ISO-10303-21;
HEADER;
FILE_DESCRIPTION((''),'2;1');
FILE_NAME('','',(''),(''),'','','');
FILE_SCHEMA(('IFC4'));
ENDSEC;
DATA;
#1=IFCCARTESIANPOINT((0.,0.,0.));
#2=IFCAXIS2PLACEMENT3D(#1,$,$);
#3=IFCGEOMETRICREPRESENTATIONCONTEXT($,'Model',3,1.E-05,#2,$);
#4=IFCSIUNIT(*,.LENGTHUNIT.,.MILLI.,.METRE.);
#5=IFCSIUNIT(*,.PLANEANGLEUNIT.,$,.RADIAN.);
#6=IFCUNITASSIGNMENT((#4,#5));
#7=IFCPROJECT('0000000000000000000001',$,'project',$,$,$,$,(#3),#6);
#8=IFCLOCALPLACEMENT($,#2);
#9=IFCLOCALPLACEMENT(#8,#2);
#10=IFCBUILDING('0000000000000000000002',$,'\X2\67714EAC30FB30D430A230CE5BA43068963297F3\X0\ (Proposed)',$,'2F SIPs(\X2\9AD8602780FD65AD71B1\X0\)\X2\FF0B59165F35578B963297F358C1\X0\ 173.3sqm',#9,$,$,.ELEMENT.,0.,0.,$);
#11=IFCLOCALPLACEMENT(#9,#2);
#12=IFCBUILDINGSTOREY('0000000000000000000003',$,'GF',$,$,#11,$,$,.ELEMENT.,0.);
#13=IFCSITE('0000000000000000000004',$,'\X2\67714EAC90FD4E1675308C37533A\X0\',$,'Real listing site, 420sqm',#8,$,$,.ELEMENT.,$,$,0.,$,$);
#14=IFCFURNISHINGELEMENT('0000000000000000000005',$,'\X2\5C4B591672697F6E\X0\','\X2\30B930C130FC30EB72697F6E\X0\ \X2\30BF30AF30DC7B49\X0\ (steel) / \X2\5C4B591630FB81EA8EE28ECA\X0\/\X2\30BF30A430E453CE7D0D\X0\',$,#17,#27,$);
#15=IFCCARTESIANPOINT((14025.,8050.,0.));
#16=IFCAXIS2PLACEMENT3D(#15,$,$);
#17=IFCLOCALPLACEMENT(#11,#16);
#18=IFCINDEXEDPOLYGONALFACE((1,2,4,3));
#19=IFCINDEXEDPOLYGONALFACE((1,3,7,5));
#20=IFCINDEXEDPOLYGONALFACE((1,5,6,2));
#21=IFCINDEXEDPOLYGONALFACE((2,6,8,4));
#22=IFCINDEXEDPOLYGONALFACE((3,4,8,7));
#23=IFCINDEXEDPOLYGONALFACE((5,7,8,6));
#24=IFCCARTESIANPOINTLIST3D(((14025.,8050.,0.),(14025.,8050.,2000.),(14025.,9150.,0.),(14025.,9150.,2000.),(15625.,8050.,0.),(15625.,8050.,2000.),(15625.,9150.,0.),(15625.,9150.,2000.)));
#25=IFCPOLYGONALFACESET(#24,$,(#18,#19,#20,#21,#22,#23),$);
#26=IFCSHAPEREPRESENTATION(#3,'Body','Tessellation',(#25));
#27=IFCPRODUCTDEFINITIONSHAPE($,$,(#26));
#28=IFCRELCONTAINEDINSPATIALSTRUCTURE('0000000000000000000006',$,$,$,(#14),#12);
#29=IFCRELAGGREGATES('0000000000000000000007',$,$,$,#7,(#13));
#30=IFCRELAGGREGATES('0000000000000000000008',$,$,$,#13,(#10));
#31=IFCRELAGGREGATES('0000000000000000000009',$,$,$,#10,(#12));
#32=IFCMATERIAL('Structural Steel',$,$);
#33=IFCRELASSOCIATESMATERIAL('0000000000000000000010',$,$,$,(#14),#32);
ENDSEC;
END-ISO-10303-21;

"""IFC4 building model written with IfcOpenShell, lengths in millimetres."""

from ifc_helpers import new_model, si_unit, frame, frame_2d, origin, place, context, project, spatial, rectangle, extrude, material, element, save


model = new_model("IFC4")

# Units and contexts
model_context = context("Model", 3, precision=1e-05, world=origin())
ifc_project = project(units=[si_unit("LENGTHUNIT", "METRE", prefix="MILLI"), si_unit("PLANEANGLEUNIT", "RADIAN")], contexts=[model_context])

# Site, building, storey
site_placement = place(None, origin())
site = spatial("IfcSite", under=ifc_project, at=site_placement, Name="東京都世田谷区", ObjectType="Real listing site, 420sqm", CompositionType="ELEMENT", RefElevation=0.0)
building_placement = place(site_placement, origin())
building = spatial("IfcBuilding", under=site, at=building_placement, Name="東京・ピアノ室と防音 (Proposed)", ObjectType="2F SIPs(高性能断熱)＋外張型防音壁 173.3sqm", CompositionType="ELEMENT", ElevationOfRefHeight=0.0, ElevationOfTerrain=0.0)
storey_placement = place(building_placement, origin())
storey = spatial("IfcBuildingStorey", under=building, at=storey_placement, Name="GF", CompositionType="ELEMENT", Elevation=0.0)

# Shared definitions
ifc_material_1 = material(Name="Structural Steel")

# Furnishing element
furnishing_1_placement = place(storey_placement, frame((14025.0, 8050.0, 0.0)))
element("IfcFurnishingElement", 1, at=furnishing_1_placement, inside=storey, material=ifc_material_1, Name="屋外物置", Description="スチール物置 タクボ等 (steel) / 屋外・自転車/タイヤ収納", context=model_context, shape_type="SweptSolid", body=[
    extrude(rectangle(XDim=1600.0, YDim=1100.0, at=frame_2d((800.0, 550.0))), frame((14025.0, 8050.0, 0.0)), (0.0, 0.0, 1.0), 2000.0),
])

save(model, "model.ifc")
